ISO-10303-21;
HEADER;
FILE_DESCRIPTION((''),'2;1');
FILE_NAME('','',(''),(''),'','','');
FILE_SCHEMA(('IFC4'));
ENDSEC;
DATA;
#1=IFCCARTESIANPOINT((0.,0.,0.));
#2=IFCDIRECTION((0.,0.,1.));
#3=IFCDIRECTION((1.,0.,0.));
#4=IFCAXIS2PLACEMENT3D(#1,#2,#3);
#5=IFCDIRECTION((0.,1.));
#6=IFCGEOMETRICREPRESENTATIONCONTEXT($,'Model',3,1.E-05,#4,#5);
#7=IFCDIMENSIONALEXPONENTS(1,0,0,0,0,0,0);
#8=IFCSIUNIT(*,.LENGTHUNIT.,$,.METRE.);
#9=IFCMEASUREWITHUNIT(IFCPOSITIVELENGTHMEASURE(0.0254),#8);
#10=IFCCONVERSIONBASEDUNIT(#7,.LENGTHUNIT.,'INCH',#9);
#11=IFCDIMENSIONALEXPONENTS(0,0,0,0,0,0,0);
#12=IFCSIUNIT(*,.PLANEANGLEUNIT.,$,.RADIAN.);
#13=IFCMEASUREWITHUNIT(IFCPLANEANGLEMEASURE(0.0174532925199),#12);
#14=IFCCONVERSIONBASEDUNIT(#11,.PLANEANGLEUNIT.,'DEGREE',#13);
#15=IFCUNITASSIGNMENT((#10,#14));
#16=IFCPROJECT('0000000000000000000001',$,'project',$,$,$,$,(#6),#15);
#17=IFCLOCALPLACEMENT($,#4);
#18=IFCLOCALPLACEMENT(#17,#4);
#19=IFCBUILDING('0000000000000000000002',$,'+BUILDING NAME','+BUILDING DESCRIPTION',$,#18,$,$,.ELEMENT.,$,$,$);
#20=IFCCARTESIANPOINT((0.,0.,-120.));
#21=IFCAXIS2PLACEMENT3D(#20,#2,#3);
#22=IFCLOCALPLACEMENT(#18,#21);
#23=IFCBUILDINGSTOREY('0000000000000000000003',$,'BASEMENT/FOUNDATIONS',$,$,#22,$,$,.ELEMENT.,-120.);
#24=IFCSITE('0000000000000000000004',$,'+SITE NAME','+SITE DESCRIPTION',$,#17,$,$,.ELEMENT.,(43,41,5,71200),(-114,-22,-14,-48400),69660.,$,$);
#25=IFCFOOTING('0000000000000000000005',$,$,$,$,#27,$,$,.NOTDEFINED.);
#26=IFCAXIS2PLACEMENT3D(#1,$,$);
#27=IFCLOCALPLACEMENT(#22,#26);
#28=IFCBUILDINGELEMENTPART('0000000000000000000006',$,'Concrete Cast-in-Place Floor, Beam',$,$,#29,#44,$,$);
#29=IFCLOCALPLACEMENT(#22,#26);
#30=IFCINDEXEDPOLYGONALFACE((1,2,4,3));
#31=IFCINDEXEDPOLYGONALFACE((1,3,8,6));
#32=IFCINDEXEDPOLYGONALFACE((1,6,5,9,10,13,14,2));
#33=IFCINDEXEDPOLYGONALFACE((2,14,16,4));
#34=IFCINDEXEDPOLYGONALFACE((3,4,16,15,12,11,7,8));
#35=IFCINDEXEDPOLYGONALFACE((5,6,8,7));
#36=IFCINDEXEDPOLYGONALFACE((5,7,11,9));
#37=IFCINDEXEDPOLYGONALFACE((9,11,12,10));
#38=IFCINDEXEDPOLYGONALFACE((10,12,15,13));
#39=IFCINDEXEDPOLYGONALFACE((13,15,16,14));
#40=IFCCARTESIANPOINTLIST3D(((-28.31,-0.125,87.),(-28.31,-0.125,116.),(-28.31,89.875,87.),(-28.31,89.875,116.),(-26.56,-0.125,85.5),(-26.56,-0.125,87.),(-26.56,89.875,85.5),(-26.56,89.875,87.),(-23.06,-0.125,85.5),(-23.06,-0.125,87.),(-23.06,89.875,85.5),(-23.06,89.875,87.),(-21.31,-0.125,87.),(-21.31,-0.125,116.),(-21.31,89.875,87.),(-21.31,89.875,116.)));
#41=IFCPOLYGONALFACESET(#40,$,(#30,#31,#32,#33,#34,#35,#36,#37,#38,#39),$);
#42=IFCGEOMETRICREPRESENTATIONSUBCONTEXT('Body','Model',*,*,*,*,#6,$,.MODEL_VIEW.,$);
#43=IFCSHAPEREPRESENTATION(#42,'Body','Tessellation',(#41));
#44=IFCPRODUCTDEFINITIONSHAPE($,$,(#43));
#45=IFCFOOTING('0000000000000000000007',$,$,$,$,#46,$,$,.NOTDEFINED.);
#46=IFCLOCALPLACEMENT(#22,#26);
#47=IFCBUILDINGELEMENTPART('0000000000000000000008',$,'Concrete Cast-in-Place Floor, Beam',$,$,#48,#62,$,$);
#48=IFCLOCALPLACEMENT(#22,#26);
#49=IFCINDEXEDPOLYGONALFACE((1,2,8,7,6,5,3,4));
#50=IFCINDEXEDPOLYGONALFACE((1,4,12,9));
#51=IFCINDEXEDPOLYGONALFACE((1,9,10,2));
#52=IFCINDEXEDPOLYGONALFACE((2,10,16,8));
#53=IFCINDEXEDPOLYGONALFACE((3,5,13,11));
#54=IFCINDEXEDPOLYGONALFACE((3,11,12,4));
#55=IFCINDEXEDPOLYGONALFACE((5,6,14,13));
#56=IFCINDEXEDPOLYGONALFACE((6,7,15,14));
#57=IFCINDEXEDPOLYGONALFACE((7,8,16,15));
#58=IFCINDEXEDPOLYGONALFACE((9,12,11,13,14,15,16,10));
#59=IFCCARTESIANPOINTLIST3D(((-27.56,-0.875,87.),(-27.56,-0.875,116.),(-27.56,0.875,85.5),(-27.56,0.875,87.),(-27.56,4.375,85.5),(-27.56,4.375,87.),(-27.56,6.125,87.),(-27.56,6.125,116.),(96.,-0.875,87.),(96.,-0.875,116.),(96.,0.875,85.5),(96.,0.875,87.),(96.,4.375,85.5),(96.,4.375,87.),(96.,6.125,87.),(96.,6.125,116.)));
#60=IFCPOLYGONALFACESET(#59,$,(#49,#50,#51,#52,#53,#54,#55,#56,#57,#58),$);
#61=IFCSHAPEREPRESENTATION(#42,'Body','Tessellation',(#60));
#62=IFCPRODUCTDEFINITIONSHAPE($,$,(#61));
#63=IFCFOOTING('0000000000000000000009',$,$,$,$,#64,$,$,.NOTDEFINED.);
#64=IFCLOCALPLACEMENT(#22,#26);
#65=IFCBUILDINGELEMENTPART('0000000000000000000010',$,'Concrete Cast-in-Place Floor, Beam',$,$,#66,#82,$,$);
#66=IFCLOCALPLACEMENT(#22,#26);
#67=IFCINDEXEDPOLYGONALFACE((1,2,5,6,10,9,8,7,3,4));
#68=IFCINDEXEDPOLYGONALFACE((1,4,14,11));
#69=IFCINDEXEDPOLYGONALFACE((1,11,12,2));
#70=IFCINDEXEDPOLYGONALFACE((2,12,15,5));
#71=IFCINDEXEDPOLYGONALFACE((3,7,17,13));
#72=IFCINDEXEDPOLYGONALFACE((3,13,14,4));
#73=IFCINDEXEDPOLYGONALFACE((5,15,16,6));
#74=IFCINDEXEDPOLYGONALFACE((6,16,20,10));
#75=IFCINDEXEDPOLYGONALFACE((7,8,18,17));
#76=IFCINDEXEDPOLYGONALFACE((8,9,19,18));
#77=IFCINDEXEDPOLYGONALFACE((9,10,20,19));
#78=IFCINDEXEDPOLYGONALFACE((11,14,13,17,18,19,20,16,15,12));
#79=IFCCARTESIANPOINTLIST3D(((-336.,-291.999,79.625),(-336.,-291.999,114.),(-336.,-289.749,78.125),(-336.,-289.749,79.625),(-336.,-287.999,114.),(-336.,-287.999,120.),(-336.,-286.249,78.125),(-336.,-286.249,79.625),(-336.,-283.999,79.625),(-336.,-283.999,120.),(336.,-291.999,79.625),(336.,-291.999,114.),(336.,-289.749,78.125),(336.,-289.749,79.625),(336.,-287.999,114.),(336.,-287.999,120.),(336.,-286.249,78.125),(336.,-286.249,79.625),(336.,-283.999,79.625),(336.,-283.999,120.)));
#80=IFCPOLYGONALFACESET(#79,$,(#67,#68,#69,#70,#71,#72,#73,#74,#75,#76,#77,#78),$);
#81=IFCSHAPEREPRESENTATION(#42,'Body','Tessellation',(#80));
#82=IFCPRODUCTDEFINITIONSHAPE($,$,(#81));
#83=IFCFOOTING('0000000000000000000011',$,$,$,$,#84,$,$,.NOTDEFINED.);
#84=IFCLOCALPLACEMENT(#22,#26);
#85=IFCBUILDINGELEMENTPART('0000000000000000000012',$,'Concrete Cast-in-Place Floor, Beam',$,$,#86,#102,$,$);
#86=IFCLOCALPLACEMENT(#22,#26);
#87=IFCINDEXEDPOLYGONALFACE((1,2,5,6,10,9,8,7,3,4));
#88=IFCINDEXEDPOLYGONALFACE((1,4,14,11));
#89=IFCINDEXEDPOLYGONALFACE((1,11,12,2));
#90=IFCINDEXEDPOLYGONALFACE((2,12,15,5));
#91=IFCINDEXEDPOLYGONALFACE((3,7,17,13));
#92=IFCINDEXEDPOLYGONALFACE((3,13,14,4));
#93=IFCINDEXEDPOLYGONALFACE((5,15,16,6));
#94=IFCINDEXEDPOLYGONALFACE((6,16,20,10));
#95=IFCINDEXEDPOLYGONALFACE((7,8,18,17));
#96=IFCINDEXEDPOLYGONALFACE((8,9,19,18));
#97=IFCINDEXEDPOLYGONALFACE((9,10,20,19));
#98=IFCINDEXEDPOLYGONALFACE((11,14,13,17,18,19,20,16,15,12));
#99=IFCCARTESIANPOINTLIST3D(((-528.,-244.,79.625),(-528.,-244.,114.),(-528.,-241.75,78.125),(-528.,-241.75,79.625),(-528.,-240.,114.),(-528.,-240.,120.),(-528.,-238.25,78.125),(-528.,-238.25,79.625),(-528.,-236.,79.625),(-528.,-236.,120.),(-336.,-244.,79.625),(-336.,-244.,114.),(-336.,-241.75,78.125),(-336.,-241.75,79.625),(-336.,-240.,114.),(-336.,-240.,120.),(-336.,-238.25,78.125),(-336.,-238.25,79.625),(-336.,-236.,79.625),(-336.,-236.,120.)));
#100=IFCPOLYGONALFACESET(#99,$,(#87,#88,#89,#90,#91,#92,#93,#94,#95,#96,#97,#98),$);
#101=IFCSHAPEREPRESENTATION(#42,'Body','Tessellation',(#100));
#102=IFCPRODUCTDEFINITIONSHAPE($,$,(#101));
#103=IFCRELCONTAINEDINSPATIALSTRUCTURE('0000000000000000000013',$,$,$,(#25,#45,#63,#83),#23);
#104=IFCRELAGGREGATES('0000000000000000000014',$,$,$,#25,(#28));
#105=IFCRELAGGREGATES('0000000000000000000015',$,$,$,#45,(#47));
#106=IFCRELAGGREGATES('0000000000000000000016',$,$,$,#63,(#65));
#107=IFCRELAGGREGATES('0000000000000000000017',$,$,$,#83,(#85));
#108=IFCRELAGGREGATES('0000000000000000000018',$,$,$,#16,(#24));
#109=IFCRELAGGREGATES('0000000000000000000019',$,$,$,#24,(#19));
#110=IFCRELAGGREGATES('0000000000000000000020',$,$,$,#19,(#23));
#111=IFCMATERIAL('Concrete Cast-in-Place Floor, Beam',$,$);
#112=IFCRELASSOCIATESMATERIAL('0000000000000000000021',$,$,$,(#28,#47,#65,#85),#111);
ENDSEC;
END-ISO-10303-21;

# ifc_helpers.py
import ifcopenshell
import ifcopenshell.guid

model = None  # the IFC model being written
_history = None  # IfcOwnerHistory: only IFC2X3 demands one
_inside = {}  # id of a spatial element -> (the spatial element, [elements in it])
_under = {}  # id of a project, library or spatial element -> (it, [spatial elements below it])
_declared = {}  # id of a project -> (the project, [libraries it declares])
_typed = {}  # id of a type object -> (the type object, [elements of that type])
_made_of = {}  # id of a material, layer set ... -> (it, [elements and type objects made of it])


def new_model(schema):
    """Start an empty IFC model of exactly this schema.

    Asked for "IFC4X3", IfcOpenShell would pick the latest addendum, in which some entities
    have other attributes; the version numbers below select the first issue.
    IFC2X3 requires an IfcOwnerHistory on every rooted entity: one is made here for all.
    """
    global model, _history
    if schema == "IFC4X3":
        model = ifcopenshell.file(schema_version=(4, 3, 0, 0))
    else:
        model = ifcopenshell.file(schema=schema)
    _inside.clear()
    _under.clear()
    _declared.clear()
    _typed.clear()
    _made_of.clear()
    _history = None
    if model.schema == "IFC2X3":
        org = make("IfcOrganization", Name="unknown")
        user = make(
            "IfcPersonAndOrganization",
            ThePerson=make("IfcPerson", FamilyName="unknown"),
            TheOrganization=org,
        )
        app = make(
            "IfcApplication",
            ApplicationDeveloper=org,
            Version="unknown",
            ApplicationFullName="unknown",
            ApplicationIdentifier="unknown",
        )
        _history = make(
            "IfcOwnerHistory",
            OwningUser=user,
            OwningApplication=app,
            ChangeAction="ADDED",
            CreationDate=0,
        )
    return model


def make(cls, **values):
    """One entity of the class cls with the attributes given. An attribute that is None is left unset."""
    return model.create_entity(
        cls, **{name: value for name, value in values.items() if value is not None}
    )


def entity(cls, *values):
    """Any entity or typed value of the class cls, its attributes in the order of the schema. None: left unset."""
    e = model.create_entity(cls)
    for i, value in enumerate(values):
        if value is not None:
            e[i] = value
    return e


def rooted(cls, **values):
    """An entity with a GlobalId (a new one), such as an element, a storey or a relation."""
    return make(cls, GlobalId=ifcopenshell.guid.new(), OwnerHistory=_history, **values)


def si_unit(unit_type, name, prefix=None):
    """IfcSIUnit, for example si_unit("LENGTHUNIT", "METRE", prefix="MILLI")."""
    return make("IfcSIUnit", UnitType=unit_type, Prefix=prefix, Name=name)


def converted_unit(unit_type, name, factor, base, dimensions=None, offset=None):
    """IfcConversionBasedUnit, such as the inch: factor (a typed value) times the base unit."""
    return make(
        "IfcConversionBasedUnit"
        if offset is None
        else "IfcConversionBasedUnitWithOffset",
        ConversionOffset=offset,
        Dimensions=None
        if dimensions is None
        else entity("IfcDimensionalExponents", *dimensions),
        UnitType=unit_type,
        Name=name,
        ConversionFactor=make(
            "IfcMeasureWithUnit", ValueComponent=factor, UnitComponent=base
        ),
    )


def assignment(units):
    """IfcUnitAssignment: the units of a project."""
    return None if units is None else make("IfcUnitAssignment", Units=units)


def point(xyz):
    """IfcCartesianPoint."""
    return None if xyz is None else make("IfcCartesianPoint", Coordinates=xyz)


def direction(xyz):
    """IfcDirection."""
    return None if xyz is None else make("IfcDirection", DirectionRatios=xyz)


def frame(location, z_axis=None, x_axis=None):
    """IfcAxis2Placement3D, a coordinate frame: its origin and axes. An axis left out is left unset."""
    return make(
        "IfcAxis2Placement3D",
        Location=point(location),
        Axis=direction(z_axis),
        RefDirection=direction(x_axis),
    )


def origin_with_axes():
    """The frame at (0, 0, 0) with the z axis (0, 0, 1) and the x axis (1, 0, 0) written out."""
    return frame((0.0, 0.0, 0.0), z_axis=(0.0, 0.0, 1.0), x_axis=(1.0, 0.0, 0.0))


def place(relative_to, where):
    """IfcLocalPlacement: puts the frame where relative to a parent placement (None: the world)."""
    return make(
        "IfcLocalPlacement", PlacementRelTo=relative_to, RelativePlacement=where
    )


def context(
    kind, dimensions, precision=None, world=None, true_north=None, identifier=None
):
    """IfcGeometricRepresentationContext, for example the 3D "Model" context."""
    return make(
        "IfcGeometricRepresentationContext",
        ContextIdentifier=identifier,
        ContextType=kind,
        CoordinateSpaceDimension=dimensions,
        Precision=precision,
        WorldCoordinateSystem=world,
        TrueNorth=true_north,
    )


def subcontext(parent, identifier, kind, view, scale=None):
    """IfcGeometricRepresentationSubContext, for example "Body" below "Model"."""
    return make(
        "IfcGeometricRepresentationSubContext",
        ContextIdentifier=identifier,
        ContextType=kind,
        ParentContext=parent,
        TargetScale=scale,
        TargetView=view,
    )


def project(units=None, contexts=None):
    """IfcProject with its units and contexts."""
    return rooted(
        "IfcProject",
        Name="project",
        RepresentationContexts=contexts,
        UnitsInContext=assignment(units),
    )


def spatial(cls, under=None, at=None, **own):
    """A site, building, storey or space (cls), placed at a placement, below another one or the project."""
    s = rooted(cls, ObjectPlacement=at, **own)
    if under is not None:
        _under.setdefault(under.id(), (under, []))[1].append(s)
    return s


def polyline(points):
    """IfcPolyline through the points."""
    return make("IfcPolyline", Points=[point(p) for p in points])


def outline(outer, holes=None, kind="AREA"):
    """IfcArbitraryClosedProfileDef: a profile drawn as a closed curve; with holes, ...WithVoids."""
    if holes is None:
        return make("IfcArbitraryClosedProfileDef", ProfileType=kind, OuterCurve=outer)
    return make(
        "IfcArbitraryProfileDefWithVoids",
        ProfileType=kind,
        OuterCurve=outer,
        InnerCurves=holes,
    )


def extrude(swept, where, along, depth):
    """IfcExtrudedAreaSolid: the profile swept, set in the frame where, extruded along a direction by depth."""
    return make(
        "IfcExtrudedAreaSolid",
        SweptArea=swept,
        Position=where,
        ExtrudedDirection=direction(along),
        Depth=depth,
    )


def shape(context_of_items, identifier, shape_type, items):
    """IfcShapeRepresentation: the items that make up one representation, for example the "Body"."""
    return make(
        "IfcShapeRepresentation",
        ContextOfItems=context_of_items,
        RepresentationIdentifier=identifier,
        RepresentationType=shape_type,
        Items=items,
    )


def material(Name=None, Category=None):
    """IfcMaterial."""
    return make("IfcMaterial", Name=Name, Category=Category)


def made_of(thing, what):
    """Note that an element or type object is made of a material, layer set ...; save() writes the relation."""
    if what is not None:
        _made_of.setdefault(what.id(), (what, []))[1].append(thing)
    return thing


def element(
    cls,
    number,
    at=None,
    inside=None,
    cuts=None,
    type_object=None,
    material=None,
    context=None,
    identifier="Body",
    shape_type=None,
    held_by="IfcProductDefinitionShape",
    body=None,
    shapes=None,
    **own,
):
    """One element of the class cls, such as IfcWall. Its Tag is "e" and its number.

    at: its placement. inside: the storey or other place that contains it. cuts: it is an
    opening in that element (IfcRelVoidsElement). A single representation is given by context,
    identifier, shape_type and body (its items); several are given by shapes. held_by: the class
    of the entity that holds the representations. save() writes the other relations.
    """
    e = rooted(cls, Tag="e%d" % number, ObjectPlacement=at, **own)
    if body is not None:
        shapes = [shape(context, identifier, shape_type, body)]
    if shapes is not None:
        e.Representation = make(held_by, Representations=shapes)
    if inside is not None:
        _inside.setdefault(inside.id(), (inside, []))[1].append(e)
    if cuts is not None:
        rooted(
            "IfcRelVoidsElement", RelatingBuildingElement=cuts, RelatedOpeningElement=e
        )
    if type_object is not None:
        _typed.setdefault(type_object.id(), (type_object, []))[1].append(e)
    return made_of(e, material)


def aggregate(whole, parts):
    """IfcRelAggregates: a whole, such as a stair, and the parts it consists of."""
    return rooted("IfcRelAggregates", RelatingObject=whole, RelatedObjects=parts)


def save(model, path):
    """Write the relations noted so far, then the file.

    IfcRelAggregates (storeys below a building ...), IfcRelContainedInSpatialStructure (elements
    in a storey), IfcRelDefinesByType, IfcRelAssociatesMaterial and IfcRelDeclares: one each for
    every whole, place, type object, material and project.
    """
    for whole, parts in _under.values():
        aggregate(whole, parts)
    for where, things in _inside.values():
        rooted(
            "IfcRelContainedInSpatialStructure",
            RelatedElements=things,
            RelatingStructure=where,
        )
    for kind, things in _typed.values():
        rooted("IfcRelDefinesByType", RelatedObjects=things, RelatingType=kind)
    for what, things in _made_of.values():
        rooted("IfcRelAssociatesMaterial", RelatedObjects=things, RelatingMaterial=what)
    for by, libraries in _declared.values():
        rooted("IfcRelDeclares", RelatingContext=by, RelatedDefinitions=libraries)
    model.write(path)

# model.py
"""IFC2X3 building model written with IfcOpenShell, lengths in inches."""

from ifc_helpers import new_model, entity, si_unit, converted_unit, direction, frame, origin_with_axes, place, context, subcontext, project, spatial, polyline, outline, extrude, material, element, aggregate, save


model = new_model("IFC2X3")

# Units and contexts
model_context = context("Model", 3, precision=1e-05, world=origin_with_axes(), true_north=direction((0.0, 1.0)))
body_context = subcontext(model_context, "Body", "Model", "MODEL_VIEW")
ifc_project = project(units=[converted_unit("LENGTHUNIT", "INCH", entity("IfcPositiveLengthMeasure", 0.0254), si_unit("LENGTHUNIT", "METRE"), dimensions=[1, 0, 0, 0, 0, 0, 0]), converted_unit("PLANEANGLEUNIT", "DEGREE", entity("IfcPlaneAngleMeasure", 0.0174532925199), si_unit("PLANEANGLEUNIT", "RADIAN"), dimensions=[0, 0, 0, 0, 0, 0, 0])], contexts=[model_context])

# Site, building, storey
site_placement = place(None, origin_with_axes())
site = spatial("IfcSite", under=ifc_project, at=site_placement, Name="+SITE NAME", Description="+SITE DESCRIPTION", CompositionType="ELEMENT", RefLatitude=(43, 41, 5, 71200), RefLongitude=(-114, -22, -14, -48400), RefElevation=69660.0)
building_placement = place(site_placement, origin_with_axes())
building = spatial("IfcBuilding", under=site, at=building_placement, Name="+BUILDING NAME", Description="+BUILDING DESCRIPTION", CompositionType="ELEMENT")
storey_placement = place(building_placement, frame((0.0, 0.0, -120.0), z_axis=(0.0, 0.0, 1.0), x_axis=(1.0, 0.0, 0.0)))
storey = spatial("IfcBuildingStorey", under=building, at=storey_placement, Name="BASEMENT/FOUNDATIONS", CompositionType="ELEMENT", Elevation=-120.0)

# Footings, building element parts
footing_1_placement = place(storey_placement, frame((-27.56, 89.875, 116.0), z_axis=(0.0, 0.0, 1.0), x_axis=(0.0, -1.0, 0.0)))
footing_1 = element("IfcFooting", 1, at=footing_1_placement, inside=storey, PredefinedType="NOTDEFINED")
ifc_material_1 = material(Name="Concrete Cast-in-Place Floor, Beam")
building_element_part_1_placement = place(footing_1_placement, origin_with_axes())
building_element_part_1 = element("IfcBuildingElementPart", 2, at=building_element_part_1_placement, material=ifc_material_1, Name="Concrete Cast-in-Place Floor, Beam", context=body_context, shape_type="SweptSolid", body=[
    extrude(outline(polyline([(-3.5, 0.0), (-3.5, -29.0), (-1.75, -29.0), (-1.75, -30.5), (1.75, -30.5), (1.75, -29.0), (3.5, -29.0), (3.5, 0.0), (-3.5, 0.0)])), frame((0.0, 2.75, 0.0), z_axis=(1.0, 0.0, 0.0), x_axis=(0.0, 1.0, 0.0)), (0.0, 0.0, 1.0), 90.0),
])
aggregate(footing_1, [building_element_part_1])
footing_2_placement = place(storey_placement, frame((-27.56, -0.125, 116.0), z_axis=(0.0, 0.0, 1.0), x_axis=(1.0, 0.0, 0.0)))
footing_2 = element("IfcFooting", 3, at=footing_2_placement, inside=storey, PredefinedType="NOTDEFINED")
building_element_part_2_placement = place(footing_2_placement, origin_with_axes())
building_element_part_2 = element("IfcBuildingElementPart", 4, at=building_element_part_2_placement, material=ifc_material_1, Name="Concrete Cast-in-Place Floor, Beam", context=body_context, shape_type="SweptSolid", body=[
    extrude(outline(polyline([(-3.5, 0.0), (-3.5, -29.0), (-1.75, -29.0), (-1.75, -30.5), (1.75, -30.5), (1.75, -29.0), (3.5, -29.0), (3.5, 0.0), (-3.5, 0.0)])), frame((0.0, 2.75, 0.0), z_axis=(1.0, 0.0, 0.0), x_axis=(0.0, 1.0, 0.0)), (0.0, 0.0, 1.0), 123.56),
])
aggregate(footing_2, [building_element_part_2])
footing_3_placement = place(storey_placement, frame((-336.0, -287.999, 120.0), z_axis=(0.0, 0.0, 1.0), x_axis=(1.0, 0.0, 0.0)))
footing_3 = element("IfcFooting", 5, at=footing_3_placement, inside=storey, PredefinedType="NOTDEFINED")
building_element_part_3_placement = place(footing_3_placement, origin_with_axes())
building_element_part_3 = element("IfcBuildingElementPart", 6, at=building_element_part_3_placement, material=ifc_material_1, Name="Concrete Cast-in-Place Floor, Beam", context=body_context, shape_type="SweptSolid", body=[
    extrude(outline(polyline([(-4.0, 0.0), (-4.0, -40.375), (-1.75, -40.375), (-1.75, -41.875), (1.75, -41.875), (1.75, -40.375), (4.0, -40.375), (4.0, -6.0), (0.0, -6.0), (0.0, 0.0), (-4.0, 0.0)])), frame((0.0, 0.0, 0.0), z_axis=(-1.0, 0.0, 0.0), x_axis=(0.0, -1.0, 0.0)), (0.0, 0.0, -1.0), 672.0),
])
aggregate(footing_3, [building_element_part_3])
footing_4_placement = place(storey_placement, frame((-528.0, -240.0, 120.0), z_axis=(0.0, 0.0, 1.0), x_axis=(1.0, 0.0, 0.0)))
footing_4 = element("IfcFooting", 7, at=footing_4_placement, inside=storey, PredefinedType="NOTDEFINED")
building_element_part_4_placement = place(footing_4_placement, origin_with_axes())
building_element_part_4 = element("IfcBuildingElementPart", 8, at=building_element_part_4_placement, material=ifc_material_1, Name="Concrete Cast-in-Place Floor, Beam", context=body_context, shape_type="SweptSolid", body=[
    extrude(outline(polyline([(-4.0, 0.0), (-4.0, -40.375), (-1.75, -40.375), (-1.75, -41.875), (1.75, -41.875), (1.75, -40.375), (4.0, -40.375), (4.0, -6.0), (0.0, -6.0), (0.0, 0.0), (-4.0, 0.0)])), frame((0.0, 0.0, 0.0), z_axis=(-1.0, 0.0, 0.0), x_axis=(0.0, -1.0, 0.0)), (0.0, 0.0, -1.0), 192.0),
])
aggregate(footing_4, [building_element_part_4])

save(model, "model.ifc")
